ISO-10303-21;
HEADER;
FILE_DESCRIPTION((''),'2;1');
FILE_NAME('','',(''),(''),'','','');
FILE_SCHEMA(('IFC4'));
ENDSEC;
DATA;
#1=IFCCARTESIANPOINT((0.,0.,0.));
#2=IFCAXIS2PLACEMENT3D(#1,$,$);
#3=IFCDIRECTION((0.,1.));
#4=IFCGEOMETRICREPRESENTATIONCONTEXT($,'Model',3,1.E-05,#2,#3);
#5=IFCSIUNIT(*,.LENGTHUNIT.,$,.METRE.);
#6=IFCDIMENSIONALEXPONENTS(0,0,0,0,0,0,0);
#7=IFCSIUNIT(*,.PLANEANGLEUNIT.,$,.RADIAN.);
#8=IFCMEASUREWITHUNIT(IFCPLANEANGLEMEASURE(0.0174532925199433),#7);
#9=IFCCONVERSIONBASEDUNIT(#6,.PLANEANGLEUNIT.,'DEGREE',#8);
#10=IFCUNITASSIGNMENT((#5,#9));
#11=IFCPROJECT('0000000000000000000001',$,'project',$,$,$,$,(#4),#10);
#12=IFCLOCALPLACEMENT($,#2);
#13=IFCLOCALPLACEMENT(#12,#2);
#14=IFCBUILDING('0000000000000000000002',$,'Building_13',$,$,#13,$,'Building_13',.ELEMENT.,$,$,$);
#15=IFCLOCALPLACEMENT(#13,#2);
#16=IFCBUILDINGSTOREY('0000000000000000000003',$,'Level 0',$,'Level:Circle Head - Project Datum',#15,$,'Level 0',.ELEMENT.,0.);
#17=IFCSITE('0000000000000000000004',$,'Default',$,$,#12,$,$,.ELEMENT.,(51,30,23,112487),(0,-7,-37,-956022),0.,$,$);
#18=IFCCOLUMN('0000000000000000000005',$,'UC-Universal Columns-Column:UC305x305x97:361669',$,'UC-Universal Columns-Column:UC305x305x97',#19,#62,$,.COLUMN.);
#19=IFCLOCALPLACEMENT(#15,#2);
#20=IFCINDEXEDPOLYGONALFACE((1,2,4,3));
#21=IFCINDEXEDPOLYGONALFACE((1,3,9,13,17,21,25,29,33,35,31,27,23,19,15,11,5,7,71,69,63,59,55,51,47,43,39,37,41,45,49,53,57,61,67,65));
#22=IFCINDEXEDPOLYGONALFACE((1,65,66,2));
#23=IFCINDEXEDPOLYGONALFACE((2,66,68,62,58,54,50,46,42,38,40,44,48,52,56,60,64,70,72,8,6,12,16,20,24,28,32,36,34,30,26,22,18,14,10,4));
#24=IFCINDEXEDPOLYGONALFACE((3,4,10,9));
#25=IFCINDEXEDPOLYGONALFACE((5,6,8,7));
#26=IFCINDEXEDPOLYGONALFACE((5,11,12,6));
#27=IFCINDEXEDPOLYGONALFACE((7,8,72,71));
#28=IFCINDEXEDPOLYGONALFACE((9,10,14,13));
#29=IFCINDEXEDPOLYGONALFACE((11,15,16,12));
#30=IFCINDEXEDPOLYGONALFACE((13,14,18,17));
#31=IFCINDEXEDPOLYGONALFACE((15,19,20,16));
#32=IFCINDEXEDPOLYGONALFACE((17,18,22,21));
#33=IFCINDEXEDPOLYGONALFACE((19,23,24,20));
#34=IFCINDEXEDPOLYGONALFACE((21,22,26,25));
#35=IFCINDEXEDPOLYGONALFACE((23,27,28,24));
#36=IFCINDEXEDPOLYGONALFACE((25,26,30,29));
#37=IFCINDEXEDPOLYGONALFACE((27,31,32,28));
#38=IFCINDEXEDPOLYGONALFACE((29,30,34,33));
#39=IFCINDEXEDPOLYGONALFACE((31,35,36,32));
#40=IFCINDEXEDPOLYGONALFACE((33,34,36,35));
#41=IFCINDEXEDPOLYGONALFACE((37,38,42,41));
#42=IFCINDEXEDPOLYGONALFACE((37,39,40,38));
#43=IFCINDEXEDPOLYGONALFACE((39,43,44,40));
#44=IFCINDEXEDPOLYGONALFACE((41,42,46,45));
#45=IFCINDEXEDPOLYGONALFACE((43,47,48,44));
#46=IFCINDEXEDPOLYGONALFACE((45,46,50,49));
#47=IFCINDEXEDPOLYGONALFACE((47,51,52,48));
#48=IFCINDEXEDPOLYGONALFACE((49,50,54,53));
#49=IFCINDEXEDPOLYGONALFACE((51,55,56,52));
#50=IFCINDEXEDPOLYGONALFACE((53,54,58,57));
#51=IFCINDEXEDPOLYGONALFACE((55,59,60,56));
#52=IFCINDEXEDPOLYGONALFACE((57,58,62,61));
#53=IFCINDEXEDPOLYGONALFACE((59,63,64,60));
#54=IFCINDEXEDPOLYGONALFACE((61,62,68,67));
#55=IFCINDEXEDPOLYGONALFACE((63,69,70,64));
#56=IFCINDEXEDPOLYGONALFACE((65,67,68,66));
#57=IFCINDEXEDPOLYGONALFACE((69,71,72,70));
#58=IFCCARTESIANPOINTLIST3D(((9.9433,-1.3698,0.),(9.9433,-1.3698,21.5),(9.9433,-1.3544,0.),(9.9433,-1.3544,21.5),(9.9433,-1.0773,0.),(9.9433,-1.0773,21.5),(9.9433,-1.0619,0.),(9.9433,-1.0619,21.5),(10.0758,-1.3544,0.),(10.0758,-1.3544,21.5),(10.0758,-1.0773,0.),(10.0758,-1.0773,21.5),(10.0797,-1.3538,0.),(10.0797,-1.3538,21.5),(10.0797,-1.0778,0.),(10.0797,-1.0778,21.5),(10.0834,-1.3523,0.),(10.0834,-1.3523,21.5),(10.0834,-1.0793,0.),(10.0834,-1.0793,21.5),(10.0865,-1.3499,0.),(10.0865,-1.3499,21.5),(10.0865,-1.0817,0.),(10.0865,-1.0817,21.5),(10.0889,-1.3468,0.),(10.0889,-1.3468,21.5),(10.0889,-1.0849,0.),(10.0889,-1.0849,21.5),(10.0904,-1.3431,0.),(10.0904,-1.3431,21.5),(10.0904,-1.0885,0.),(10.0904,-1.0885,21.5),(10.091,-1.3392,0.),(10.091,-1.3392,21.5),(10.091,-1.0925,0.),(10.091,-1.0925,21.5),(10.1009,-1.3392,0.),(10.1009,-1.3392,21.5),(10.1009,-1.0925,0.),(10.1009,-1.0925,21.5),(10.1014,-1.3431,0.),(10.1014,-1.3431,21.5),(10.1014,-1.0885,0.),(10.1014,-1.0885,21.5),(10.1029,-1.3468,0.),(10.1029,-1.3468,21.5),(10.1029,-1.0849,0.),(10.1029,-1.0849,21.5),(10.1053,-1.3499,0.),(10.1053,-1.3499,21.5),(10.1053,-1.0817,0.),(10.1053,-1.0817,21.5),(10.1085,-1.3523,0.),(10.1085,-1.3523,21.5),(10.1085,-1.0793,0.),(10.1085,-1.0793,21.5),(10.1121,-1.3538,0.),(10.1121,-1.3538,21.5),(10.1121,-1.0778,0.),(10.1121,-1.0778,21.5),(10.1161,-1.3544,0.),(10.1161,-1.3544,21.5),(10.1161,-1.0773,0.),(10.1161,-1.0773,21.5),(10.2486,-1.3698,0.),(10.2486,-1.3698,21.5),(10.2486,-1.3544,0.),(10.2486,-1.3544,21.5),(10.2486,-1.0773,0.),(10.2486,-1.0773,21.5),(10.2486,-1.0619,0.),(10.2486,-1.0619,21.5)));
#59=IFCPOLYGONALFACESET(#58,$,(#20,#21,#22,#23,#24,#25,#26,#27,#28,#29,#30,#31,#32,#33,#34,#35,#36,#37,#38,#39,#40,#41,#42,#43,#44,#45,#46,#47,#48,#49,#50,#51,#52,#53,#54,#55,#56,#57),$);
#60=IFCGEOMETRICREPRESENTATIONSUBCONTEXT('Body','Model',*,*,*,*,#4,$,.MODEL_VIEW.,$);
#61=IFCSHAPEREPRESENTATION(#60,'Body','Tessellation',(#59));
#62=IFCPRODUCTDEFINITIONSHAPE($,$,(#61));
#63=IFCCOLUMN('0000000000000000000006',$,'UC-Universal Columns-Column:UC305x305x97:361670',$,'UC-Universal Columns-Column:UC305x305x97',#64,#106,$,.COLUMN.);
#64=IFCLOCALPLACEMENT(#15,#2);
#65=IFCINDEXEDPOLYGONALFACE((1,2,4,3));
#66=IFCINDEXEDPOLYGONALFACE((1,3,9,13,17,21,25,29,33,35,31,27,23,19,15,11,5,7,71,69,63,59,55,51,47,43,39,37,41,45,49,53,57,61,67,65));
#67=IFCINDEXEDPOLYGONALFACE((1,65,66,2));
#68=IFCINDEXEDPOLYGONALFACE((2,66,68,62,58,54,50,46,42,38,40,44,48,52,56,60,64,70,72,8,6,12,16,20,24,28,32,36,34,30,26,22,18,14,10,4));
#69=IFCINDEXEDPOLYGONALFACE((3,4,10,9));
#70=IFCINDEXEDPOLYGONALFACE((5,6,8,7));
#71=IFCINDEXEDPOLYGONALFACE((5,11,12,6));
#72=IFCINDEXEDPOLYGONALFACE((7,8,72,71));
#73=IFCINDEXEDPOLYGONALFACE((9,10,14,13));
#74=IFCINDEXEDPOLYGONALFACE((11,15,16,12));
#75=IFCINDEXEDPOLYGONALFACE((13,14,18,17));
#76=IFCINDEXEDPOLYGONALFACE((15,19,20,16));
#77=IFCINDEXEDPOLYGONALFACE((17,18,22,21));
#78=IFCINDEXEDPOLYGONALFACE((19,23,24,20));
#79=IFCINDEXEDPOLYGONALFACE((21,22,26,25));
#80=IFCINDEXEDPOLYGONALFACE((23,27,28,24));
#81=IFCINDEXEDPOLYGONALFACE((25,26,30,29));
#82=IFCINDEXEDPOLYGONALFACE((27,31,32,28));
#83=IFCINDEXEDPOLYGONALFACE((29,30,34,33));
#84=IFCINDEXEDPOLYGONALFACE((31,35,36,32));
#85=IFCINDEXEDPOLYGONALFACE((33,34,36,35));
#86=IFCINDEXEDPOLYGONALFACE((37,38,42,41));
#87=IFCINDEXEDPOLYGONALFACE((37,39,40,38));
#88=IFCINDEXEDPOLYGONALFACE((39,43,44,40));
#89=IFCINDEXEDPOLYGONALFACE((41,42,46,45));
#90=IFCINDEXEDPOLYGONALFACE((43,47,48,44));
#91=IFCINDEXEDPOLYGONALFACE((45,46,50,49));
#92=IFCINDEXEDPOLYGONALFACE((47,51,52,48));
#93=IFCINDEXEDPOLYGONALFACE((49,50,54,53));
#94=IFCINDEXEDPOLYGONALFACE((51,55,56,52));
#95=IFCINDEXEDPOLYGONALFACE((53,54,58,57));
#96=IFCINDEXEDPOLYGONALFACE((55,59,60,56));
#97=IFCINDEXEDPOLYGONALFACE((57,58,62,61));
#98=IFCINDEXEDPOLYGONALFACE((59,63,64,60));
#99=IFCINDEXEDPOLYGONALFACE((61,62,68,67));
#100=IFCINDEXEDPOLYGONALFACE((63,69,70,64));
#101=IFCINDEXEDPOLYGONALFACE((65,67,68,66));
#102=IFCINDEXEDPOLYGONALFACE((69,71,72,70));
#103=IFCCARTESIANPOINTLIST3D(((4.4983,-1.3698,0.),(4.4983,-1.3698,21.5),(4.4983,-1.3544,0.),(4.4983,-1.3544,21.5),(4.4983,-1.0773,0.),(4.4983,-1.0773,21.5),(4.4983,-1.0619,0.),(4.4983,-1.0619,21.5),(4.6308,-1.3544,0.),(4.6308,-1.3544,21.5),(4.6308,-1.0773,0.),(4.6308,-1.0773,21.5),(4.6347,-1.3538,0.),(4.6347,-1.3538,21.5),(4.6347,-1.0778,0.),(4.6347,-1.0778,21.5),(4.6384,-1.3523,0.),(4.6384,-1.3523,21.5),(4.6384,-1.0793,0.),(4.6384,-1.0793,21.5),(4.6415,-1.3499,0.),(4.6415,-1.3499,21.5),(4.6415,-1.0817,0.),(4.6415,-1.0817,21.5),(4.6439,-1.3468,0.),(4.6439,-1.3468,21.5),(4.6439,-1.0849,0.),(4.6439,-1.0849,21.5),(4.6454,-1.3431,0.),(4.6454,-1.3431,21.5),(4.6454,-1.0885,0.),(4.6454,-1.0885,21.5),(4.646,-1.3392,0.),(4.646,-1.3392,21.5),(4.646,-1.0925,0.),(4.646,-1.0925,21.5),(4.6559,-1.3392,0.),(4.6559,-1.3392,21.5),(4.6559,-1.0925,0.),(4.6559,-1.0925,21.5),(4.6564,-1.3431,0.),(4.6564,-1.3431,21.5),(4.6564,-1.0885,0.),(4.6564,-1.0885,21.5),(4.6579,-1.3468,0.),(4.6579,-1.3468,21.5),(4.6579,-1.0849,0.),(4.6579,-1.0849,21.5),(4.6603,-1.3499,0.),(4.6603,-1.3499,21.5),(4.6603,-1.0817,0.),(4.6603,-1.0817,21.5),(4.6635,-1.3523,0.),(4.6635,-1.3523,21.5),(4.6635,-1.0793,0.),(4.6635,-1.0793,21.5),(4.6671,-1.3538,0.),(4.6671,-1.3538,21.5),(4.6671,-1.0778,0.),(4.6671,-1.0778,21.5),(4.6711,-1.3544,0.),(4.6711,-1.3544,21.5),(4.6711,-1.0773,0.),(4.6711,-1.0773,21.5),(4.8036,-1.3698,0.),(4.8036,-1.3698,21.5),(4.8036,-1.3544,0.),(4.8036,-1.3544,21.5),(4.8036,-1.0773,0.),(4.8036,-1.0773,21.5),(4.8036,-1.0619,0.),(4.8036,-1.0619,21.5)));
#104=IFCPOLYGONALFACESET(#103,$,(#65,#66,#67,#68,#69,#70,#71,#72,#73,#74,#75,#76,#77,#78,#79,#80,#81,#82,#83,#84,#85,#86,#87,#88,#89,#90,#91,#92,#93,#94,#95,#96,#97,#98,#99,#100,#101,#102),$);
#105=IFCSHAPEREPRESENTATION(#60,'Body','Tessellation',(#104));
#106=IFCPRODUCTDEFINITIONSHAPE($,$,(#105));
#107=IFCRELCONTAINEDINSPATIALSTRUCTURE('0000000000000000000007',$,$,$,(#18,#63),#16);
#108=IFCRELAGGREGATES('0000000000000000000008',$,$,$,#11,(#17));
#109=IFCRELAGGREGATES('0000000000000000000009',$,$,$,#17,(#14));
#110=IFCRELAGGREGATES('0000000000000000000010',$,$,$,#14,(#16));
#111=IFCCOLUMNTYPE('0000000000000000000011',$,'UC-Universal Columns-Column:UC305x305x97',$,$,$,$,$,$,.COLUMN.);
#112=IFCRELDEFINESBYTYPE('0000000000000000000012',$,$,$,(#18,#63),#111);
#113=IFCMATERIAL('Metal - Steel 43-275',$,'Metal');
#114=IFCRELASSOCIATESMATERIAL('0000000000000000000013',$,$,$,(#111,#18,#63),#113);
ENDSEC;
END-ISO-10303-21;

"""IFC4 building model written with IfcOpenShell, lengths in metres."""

from ifc_helpers import new_model, entity, si_unit, converted_unit, direction, frame, origin, place, context, subcontext, project, spatial, line, arc, indexed_curve, outline, extrude, source, transform, mapped, material, type_object, type_shapes, element, save


model = new_model("IFC4")

# Units and contexts
model_context = context("Model", 3, precision=1e-05, world=origin(), true_north=direction((0.0, 1.0)))
body_context = subcontext(model_context, "Body", "Model", "MODEL_VIEW")
ifc_project = project(units=[si_unit("LENGTHUNIT", "METRE"), converted_unit("PLANEANGLEUNIT", "DEGREE", entity("IfcPlaneAngleMeasure", 0.0174532925199433), si_unit("PLANEANGLEUNIT", "RADIAN"), dimensions=[0, 0, 0, 0, 0, 0, 0])], contexts=[model_context])

# Site, building, storey
site_placement = place(None, origin())
site = spatial("IfcSite", under=ifc_project, at=site_placement, Name="Default", CompositionType="ELEMENT", RefLatitude=(51, 30, 23, 112487), RefLongitude=(0, -7, -37, -956022), RefElevation=0.0)
building_placement = place(site_placement, origin())
building = spatial("IfcBuilding", under=site, at=building_placement, Name="Building_13", LongName="Building_13", CompositionType="ELEMENT")
storey_placement = place(building_placement, origin())
storey = spatial("IfcBuildingStorey", under=building, at=storey_placement, Name="Level 0", ObjectType="Level:Circle Head - Project Datum", LongName="Level 0", CompositionType="ELEMENT", Elevation=0.0)

# Columns
ifc_material_1 = material(Name="Metal - Steel 43-275", Category="Metal")
column_type_1 = type_object("IfcColumnType", Name="UC-Universal Columns-Column:UC305x305x97", PredefinedType="COLUMN", material=ifc_material_1)
shared_shape_1 = source(origin(), body_context, "Body", "SweptSolid", [
    extrude(outline(indexed_curve([(-0.154, -0.1527), (-0.1386, -0.1527), (-0.1386, -0.0201), (-0.1341, -0.0094), (-0.1234, -0.005), (0.1234, -0.005), (0.1341, -0.0094), (0.1386, -0.0202), (0.1386, -0.1527), (0.154, -0.1527), (0.154, 0.1527), (0.1386, 0.1527), (0.1386, 0.0201), (0.1341, 0.0094), (0.1234, 0.0049), (-0.1234, 0.0049), (-0.1341, 0.0094), (-0.1386, 0.0202), (-0.1386, 0.1527), (-0.154, 0.1527)], segments=[line(1, 2, 3), arc(3, 4, 5), line(5, 6), arc(6, 7, 8), line(8, 9, 10, 11, 12, 13), arc(13, 14, 15), line(15, 16), arc(16, 17, 18), line(18, 19, 20, 1)], self_intersect=False)), frame((0.0, 0.0, 0.0), z_axis=(0.0, 0.0, 1.0), x_axis=(0.0, 1.0, 0.0)), (0.0, 0.0, 1.0), 21.5),
])
type_shapes(column_type_1, [shared_shape_1])
for number, where, name in (
    (1, (10.0959, -1.2158, 0.0), "UC-Universal Columns-Column:UC305x305x97:361669"),
    (2, (4.6509, -1.2158, 0.0), "UC-Universal Columns-Column:UC305x305x97:361670"),
):
    element("IfcColumn", number, at=place(storey_placement, frame(where)), inside=storey, type_object=column_type_1, material=ifc_material_1, Name=name, ObjectType="UC-Universal Columns-Column:UC305x305x97", PredefinedType="COLUMN", context=body_context, shape_type="MappedRepresentation", body=[
        mapped(shared_shape_1, transform((0.0, 0.0, 0.0), scale=1.0)),
    ])

save(model, "model.ifc")
